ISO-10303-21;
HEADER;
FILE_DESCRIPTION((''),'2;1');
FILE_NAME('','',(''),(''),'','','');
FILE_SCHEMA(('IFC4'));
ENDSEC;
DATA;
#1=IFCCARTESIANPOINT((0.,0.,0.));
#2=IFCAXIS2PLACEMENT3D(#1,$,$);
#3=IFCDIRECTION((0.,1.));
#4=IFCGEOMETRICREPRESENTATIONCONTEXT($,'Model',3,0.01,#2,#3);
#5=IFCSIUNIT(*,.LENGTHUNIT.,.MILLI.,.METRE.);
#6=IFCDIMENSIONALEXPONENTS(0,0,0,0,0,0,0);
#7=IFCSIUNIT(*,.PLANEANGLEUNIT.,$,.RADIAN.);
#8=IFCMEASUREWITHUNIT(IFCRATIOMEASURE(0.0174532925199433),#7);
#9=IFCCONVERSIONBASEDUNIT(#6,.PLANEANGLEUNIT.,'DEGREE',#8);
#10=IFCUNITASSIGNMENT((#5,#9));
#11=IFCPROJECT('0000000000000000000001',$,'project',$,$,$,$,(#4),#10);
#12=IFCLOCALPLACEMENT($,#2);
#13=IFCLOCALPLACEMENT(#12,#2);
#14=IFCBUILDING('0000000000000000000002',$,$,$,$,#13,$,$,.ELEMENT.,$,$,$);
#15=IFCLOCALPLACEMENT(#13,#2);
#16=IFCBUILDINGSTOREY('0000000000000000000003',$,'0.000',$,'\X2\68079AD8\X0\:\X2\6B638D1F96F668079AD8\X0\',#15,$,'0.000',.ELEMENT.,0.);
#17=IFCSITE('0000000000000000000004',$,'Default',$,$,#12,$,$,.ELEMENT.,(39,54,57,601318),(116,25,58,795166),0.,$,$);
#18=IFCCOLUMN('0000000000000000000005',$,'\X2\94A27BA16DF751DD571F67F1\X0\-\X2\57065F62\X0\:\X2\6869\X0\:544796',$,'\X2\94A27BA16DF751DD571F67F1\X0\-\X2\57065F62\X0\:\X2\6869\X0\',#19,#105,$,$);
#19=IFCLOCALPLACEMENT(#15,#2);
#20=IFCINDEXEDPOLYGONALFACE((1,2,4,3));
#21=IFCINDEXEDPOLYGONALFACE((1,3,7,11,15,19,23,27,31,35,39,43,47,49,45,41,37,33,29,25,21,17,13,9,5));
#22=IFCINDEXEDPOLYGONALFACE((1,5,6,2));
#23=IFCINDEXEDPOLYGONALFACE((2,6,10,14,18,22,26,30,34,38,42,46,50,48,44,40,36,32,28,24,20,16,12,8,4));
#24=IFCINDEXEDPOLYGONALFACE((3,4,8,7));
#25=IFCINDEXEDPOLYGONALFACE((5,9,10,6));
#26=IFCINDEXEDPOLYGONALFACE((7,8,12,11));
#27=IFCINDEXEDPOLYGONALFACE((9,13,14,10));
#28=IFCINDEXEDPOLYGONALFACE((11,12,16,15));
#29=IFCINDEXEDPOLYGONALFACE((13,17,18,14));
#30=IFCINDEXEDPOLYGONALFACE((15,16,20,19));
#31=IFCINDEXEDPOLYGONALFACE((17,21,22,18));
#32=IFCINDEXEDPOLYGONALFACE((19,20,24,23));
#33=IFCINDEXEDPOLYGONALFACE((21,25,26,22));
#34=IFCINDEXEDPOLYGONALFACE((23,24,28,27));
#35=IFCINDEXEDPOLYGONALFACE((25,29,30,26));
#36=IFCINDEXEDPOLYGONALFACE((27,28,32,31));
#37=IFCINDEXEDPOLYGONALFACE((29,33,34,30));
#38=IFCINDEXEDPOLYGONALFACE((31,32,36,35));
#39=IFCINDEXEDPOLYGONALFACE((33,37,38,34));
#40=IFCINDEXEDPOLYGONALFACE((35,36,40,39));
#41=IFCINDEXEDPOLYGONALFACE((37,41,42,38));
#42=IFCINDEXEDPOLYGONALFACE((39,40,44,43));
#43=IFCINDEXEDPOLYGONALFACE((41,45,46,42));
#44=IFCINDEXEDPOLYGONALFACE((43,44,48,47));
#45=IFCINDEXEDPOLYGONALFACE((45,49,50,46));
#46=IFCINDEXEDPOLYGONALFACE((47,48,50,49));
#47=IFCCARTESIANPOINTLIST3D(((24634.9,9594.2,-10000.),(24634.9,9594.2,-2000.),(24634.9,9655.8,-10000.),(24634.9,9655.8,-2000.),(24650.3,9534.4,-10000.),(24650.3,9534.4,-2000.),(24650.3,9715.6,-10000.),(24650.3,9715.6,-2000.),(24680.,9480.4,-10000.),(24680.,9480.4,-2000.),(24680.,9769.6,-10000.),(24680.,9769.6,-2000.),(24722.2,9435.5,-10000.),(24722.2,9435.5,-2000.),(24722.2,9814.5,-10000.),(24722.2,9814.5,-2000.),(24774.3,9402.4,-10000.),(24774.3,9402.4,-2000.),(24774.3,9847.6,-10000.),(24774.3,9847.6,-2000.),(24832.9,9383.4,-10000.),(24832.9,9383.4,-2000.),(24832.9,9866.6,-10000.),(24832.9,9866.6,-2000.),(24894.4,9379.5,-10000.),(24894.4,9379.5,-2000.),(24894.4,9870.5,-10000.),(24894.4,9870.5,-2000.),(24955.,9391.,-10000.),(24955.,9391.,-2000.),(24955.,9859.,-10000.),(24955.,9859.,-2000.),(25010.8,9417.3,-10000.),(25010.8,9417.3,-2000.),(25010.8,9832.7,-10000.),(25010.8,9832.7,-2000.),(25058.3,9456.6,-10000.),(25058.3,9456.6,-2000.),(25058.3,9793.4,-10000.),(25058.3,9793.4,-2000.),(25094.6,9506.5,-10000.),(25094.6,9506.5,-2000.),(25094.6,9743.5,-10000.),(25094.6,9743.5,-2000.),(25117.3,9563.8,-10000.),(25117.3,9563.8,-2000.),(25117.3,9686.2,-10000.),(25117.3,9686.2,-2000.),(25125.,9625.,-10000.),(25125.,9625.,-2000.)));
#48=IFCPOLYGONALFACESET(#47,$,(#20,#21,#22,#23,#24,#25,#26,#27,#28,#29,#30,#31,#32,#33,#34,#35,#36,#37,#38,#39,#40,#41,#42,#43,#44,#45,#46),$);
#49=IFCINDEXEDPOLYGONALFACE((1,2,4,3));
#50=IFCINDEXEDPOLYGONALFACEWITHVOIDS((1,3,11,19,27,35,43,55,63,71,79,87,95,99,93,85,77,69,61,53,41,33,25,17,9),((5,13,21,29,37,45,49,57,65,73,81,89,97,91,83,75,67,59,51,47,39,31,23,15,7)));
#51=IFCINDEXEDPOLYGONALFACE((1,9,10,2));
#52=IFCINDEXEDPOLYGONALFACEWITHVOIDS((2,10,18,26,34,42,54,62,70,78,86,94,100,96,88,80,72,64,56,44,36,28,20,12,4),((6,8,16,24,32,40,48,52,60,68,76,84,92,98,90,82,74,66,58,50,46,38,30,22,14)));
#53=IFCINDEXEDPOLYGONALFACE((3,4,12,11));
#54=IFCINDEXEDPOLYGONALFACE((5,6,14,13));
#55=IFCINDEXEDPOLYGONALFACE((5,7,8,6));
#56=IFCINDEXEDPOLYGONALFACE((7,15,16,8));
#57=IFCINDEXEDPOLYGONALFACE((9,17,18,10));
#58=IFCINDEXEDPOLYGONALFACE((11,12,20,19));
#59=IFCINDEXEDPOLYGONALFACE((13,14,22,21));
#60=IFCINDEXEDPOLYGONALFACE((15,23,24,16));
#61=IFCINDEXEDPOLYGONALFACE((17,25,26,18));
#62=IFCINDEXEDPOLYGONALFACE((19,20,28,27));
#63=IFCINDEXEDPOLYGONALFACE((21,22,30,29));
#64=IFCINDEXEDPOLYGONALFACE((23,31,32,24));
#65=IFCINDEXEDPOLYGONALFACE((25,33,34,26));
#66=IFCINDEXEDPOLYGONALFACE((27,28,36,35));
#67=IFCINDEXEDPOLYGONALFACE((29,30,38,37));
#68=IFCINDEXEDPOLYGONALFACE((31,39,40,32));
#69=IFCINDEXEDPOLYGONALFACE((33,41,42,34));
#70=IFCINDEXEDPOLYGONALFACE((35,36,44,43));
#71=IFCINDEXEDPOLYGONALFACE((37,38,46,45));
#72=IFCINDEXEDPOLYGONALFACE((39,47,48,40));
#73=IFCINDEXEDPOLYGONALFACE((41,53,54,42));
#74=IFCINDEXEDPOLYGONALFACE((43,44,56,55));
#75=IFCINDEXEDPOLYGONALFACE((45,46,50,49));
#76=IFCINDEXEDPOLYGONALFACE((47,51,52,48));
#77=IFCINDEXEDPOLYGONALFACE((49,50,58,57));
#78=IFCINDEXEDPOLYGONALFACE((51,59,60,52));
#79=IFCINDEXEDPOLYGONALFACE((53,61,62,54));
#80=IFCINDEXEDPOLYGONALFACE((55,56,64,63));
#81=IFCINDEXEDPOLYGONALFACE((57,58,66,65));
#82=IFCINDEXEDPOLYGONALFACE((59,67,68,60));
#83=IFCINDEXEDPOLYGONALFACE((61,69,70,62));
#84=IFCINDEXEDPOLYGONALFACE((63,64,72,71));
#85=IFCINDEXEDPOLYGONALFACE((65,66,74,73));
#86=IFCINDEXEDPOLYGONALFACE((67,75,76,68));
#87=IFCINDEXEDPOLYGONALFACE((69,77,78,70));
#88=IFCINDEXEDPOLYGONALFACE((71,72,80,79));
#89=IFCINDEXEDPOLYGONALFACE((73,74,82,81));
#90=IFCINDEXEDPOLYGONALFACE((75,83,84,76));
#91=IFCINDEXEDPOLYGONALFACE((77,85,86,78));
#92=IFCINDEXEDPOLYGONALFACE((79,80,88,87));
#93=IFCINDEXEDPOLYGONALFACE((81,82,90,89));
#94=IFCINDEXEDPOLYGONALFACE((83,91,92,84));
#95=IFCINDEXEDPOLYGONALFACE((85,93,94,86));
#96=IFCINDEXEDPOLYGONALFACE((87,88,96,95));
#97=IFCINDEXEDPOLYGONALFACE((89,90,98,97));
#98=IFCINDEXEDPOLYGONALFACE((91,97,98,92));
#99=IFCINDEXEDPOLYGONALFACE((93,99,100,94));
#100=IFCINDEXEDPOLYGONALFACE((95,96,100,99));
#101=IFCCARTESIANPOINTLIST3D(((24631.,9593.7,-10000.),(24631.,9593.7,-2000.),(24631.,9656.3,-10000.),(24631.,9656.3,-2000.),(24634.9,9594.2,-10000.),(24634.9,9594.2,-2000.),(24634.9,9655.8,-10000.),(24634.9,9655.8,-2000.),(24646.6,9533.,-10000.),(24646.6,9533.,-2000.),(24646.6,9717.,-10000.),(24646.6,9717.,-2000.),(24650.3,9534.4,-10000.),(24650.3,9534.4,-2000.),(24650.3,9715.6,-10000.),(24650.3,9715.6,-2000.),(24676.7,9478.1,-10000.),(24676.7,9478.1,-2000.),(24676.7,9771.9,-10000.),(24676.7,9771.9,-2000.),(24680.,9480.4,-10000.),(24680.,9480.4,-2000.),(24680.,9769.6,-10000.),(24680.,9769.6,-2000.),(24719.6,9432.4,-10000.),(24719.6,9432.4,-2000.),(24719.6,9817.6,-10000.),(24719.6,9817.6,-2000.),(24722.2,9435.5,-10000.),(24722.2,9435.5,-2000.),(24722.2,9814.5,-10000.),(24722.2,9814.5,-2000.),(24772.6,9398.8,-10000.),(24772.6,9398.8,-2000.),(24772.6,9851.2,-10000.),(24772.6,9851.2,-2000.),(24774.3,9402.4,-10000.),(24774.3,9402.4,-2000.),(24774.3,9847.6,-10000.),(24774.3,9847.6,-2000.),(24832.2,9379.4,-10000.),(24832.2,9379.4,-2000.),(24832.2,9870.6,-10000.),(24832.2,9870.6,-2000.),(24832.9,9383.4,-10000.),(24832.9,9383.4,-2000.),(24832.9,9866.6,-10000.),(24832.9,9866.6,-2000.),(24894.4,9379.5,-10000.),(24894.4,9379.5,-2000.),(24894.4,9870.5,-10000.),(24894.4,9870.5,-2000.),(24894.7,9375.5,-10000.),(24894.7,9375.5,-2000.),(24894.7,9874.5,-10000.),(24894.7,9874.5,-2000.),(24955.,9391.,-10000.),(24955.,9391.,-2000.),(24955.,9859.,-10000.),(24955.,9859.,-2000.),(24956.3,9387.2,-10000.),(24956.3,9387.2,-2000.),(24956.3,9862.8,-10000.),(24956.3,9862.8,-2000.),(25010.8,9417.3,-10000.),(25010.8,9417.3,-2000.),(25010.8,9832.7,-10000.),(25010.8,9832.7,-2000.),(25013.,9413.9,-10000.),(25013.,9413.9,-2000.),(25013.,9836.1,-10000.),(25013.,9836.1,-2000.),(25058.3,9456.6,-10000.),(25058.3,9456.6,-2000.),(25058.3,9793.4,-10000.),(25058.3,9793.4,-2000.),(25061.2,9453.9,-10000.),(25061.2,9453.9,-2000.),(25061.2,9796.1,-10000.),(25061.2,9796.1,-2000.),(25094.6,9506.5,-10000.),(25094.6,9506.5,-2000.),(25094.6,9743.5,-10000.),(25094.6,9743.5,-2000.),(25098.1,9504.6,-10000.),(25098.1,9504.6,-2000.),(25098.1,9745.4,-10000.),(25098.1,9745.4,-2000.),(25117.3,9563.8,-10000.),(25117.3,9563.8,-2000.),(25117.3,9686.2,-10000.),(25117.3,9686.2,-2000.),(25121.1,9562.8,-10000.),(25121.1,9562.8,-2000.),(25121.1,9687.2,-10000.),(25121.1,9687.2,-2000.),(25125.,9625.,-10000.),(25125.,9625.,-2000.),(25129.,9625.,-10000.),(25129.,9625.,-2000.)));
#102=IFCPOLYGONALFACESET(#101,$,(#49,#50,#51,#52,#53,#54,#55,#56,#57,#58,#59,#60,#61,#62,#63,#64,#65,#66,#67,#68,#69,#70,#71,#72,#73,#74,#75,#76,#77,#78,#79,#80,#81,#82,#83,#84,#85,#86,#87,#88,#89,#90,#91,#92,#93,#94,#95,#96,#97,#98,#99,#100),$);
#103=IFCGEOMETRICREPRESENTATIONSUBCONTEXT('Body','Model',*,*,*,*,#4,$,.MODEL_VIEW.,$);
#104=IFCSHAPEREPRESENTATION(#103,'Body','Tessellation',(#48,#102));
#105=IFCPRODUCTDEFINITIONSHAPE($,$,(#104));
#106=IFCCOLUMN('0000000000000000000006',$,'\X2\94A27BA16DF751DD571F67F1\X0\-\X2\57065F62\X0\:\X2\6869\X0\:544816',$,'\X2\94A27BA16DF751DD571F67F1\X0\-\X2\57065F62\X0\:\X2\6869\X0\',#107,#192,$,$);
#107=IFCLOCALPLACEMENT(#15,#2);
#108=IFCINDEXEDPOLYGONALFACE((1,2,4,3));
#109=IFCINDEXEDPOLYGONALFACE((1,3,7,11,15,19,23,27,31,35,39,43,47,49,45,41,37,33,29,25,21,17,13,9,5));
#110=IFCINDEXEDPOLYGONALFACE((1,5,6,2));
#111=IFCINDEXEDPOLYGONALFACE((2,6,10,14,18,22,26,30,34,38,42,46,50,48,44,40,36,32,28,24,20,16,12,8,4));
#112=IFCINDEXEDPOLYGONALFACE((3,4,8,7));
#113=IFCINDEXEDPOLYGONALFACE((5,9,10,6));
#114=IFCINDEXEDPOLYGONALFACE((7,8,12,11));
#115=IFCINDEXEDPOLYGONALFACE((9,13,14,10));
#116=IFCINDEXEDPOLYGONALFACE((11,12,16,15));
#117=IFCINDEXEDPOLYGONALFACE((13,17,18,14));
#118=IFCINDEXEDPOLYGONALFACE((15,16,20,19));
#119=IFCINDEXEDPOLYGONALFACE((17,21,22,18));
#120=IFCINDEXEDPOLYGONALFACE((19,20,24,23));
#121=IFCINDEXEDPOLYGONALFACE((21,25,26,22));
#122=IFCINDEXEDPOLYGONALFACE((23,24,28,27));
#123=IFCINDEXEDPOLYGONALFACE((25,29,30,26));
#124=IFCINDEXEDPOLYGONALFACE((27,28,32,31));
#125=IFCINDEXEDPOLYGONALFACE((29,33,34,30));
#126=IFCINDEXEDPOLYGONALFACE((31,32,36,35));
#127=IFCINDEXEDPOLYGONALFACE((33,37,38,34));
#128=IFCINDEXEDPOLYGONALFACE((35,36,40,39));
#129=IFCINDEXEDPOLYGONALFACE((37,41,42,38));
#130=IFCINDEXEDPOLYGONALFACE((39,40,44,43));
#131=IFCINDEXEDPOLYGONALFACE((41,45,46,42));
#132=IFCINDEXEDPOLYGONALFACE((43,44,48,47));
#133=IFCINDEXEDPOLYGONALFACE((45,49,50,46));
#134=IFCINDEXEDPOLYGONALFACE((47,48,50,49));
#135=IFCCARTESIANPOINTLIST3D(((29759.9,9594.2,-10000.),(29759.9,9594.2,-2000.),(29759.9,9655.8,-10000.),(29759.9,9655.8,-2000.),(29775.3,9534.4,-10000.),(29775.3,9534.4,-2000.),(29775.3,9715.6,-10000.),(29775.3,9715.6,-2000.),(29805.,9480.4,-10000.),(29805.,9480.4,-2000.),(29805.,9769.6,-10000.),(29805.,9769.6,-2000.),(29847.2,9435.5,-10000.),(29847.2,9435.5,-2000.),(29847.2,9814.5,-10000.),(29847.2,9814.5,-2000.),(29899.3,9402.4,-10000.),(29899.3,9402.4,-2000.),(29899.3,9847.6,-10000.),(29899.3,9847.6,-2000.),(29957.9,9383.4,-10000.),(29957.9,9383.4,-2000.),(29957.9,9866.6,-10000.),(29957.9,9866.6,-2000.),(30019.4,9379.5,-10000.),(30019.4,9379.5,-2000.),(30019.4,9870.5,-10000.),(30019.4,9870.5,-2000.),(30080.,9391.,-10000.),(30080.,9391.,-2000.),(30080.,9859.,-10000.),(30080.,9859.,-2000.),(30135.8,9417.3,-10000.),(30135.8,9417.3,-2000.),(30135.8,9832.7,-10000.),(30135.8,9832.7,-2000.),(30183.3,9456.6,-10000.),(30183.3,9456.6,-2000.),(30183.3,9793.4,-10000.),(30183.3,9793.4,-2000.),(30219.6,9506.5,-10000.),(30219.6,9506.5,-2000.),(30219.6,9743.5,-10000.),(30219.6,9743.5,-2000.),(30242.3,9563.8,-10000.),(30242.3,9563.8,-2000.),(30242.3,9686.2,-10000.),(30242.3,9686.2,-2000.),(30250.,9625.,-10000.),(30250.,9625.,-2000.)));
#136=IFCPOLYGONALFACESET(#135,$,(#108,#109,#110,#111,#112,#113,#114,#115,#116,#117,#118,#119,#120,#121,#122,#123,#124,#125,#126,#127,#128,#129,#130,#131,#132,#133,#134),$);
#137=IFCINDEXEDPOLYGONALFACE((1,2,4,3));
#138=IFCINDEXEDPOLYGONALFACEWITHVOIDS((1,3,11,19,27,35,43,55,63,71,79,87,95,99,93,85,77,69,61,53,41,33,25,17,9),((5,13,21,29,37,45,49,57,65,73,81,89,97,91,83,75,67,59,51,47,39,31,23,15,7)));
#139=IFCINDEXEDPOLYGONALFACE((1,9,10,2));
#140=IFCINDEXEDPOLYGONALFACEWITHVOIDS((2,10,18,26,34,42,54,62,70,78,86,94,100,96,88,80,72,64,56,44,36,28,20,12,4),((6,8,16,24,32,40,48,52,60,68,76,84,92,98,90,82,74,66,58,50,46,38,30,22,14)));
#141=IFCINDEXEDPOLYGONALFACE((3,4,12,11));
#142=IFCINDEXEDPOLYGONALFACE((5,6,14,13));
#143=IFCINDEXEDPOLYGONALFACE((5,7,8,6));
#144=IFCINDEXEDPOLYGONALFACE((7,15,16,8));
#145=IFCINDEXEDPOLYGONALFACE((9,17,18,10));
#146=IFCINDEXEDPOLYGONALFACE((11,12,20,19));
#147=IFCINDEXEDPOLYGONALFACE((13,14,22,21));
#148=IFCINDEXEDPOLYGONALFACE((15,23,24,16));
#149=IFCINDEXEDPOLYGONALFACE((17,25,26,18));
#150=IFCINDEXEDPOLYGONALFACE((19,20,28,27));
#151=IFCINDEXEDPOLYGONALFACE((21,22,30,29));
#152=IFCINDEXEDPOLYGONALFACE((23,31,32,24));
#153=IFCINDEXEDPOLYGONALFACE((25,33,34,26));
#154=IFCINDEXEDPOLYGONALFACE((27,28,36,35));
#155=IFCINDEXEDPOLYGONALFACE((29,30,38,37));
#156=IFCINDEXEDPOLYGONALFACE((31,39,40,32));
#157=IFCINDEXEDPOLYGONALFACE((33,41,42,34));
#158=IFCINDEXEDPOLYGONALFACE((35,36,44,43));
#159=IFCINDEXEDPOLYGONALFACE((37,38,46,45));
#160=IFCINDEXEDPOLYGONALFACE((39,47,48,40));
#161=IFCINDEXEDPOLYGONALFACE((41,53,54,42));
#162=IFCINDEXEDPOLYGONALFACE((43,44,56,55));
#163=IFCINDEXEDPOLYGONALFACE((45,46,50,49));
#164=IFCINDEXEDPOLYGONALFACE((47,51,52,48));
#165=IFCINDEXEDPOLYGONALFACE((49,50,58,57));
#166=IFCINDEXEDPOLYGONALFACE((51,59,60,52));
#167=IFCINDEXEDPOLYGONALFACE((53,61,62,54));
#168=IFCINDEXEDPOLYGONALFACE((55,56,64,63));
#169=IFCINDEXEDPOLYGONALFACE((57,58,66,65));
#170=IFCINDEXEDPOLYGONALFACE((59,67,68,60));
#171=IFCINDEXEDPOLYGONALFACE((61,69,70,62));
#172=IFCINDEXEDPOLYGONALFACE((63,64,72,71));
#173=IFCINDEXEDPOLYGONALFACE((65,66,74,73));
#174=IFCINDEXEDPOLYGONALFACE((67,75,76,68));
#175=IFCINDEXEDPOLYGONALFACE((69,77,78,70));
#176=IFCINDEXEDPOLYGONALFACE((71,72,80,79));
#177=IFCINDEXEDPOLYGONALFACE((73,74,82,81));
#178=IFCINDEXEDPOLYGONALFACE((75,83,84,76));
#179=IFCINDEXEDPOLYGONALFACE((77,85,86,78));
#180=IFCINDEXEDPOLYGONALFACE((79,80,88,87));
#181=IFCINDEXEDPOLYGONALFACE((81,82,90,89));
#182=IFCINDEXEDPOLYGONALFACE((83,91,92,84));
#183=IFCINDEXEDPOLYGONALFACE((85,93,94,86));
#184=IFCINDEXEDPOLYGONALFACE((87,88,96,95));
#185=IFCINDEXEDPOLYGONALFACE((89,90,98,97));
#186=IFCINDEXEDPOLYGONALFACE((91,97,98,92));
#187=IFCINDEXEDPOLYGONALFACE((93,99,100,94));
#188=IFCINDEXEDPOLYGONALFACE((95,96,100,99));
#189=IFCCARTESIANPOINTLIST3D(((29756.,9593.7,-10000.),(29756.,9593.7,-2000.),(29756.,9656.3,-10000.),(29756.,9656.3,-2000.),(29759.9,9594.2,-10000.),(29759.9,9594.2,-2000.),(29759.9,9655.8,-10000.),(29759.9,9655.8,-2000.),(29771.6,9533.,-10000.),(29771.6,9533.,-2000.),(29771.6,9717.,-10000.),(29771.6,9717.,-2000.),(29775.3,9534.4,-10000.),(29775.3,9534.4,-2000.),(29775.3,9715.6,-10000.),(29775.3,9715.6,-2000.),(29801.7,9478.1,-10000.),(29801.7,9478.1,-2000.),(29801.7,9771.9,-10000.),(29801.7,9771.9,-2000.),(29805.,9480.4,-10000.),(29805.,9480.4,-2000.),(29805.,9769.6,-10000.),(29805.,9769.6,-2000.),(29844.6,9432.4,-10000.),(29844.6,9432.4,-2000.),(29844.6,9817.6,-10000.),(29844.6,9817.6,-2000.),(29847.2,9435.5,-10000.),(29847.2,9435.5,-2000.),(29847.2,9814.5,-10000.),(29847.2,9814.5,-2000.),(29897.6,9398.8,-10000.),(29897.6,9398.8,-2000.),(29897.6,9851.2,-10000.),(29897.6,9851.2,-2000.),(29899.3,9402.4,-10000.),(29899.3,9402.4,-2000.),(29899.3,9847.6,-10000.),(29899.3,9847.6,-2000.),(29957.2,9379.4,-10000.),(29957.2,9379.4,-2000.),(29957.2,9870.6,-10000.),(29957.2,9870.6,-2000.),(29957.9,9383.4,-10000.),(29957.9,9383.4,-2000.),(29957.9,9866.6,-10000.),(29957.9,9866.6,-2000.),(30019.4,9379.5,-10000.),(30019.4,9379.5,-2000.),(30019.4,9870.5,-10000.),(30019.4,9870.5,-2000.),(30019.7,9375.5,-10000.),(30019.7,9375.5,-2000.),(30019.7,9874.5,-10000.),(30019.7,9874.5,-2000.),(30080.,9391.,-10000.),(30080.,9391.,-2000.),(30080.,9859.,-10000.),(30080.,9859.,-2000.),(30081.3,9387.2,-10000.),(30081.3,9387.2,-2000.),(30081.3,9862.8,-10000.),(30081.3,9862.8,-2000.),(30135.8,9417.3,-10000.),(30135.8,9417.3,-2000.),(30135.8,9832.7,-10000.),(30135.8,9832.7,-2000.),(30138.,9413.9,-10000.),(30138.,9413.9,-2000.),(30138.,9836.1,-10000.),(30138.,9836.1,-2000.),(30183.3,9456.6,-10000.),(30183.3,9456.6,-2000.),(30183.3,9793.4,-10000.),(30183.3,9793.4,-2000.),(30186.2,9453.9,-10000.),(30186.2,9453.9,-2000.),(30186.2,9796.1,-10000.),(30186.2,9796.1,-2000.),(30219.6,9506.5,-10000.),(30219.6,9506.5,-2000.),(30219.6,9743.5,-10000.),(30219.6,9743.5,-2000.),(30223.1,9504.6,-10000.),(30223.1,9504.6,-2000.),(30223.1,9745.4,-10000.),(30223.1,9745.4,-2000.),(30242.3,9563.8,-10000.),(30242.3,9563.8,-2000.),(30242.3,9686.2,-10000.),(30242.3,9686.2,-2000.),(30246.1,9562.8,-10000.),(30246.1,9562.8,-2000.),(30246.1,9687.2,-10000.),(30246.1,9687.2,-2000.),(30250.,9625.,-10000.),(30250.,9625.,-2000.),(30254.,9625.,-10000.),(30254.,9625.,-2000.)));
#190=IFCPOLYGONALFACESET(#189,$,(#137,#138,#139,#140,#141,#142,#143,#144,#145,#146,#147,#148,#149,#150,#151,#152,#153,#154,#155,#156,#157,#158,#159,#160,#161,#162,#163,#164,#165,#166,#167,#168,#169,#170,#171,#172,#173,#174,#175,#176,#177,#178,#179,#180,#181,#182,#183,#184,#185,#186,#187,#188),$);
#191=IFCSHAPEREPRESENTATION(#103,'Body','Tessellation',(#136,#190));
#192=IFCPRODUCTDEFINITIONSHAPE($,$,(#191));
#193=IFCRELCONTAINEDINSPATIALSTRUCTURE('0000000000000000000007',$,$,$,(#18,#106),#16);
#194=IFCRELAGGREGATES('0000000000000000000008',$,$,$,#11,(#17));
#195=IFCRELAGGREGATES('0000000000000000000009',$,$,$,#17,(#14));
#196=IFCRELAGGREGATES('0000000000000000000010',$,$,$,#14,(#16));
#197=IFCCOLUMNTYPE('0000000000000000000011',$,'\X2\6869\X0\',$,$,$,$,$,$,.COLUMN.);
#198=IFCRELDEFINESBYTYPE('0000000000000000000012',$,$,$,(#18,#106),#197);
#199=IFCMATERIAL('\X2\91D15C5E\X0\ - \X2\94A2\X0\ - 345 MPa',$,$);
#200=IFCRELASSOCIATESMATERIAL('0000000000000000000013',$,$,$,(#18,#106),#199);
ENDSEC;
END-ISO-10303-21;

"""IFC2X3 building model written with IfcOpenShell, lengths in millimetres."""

from ifc_helpers import new_model, entity, si_unit, converted_unit, direction, frame, frame_2d, origin, place, context, subcontext, project, spatial, circle, hollow_circle, extrude, source, transform, mapped, material, type_object, type_shapes, element, save


model = new_model("IFC2X3")

# Units and contexts
model_context = context("Model", 3, precision=0.01, world=origin(), true_north=direction((0.0, 1.0)))
body_context = subcontext(model_context, "Body", "Model", "MODEL_VIEW")
ifc_project = project(units=[si_unit("LENGTHUNIT", "METRE", prefix="MILLI"), converted_unit("PLANEANGLEUNIT", "DEGREE", entity("IfcRatioMeasure", 0.0174532925199433), si_unit("PLANEANGLEUNIT", "RADIAN"), dimensions=[0, 0, 0, 0, 0, 0, 0])], contexts=[model_context])

# Site, building, storey
site_placement = place(None, origin())
site = spatial("IfcSite", under=ifc_project, at=site_placement, Name="Default", CompositionType="ELEMENT", RefLatitude=(39, 54, 57, 601318), RefLongitude=(116, 25, 58, 795166), RefElevation=0.0)
building_placement = place(site_placement, origin())
building = spatial("IfcBuilding", under=site, at=building_placement, CompositionType="ELEMENT")
storey_placement = place(building_placement, origin())
storey = spatial("IfcBuildingStorey", under=building, at=storey_placement, Name="0.000", ObjectType="标高:正负零标高", LongName="0.000", CompositionType="ELEMENT", Elevation=0.0)

# Columns
ifc_material_1 = material(Name="金属 - 钢 - 345 MPa")
column_type_1 = type_object("IfcColumnType", Name="桩", PredefinedType="COLUMN")
shared_shape_1 = source(origin(), body_context, "Body", "SweptSolid", [
    extrude(circle(Radius=246.0, at=frame_2d((0.0, 0.0), x_axis=(1.0, 0.0))), frame((0.0, 0.0, -10000.0)), (0.0, 0.0, 1.0), 8000.0),
    extrude(hollow_circle(Radius=250.0, WallThickness=4.0, at=frame_2d((0.0, 0.0), x_axis=(1.0, 0.0))), frame((0.0, 0.0, -10000.0)), (0.0, 0.0, 1.0), 8000.0),
])
type_shapes(column_type_1, [shared_shape_1])
for number, where, name in (
    (1, (24879.0, 9625.0, 0.0), "钢管混凝土柱-圆形:桩:544796"),
    (2, (30004.0, 9625.0, 0.0), "钢管混凝土柱-圆形:桩:544816"),
):
    element("IfcColumn", number, at=place(storey_placement, frame(where)), inside=storey, type_object=column_type_1, material=ifc_material_1, Name=name, ObjectType="钢管混凝土柱-圆形:桩", context=body_context, shape_type="MappedRepresentation", body=[
        mapped(shared_shape_1, transform((0.0, 0.0, 0.0), scale=1.0)),
    ])

save(model, "model.ifc")
